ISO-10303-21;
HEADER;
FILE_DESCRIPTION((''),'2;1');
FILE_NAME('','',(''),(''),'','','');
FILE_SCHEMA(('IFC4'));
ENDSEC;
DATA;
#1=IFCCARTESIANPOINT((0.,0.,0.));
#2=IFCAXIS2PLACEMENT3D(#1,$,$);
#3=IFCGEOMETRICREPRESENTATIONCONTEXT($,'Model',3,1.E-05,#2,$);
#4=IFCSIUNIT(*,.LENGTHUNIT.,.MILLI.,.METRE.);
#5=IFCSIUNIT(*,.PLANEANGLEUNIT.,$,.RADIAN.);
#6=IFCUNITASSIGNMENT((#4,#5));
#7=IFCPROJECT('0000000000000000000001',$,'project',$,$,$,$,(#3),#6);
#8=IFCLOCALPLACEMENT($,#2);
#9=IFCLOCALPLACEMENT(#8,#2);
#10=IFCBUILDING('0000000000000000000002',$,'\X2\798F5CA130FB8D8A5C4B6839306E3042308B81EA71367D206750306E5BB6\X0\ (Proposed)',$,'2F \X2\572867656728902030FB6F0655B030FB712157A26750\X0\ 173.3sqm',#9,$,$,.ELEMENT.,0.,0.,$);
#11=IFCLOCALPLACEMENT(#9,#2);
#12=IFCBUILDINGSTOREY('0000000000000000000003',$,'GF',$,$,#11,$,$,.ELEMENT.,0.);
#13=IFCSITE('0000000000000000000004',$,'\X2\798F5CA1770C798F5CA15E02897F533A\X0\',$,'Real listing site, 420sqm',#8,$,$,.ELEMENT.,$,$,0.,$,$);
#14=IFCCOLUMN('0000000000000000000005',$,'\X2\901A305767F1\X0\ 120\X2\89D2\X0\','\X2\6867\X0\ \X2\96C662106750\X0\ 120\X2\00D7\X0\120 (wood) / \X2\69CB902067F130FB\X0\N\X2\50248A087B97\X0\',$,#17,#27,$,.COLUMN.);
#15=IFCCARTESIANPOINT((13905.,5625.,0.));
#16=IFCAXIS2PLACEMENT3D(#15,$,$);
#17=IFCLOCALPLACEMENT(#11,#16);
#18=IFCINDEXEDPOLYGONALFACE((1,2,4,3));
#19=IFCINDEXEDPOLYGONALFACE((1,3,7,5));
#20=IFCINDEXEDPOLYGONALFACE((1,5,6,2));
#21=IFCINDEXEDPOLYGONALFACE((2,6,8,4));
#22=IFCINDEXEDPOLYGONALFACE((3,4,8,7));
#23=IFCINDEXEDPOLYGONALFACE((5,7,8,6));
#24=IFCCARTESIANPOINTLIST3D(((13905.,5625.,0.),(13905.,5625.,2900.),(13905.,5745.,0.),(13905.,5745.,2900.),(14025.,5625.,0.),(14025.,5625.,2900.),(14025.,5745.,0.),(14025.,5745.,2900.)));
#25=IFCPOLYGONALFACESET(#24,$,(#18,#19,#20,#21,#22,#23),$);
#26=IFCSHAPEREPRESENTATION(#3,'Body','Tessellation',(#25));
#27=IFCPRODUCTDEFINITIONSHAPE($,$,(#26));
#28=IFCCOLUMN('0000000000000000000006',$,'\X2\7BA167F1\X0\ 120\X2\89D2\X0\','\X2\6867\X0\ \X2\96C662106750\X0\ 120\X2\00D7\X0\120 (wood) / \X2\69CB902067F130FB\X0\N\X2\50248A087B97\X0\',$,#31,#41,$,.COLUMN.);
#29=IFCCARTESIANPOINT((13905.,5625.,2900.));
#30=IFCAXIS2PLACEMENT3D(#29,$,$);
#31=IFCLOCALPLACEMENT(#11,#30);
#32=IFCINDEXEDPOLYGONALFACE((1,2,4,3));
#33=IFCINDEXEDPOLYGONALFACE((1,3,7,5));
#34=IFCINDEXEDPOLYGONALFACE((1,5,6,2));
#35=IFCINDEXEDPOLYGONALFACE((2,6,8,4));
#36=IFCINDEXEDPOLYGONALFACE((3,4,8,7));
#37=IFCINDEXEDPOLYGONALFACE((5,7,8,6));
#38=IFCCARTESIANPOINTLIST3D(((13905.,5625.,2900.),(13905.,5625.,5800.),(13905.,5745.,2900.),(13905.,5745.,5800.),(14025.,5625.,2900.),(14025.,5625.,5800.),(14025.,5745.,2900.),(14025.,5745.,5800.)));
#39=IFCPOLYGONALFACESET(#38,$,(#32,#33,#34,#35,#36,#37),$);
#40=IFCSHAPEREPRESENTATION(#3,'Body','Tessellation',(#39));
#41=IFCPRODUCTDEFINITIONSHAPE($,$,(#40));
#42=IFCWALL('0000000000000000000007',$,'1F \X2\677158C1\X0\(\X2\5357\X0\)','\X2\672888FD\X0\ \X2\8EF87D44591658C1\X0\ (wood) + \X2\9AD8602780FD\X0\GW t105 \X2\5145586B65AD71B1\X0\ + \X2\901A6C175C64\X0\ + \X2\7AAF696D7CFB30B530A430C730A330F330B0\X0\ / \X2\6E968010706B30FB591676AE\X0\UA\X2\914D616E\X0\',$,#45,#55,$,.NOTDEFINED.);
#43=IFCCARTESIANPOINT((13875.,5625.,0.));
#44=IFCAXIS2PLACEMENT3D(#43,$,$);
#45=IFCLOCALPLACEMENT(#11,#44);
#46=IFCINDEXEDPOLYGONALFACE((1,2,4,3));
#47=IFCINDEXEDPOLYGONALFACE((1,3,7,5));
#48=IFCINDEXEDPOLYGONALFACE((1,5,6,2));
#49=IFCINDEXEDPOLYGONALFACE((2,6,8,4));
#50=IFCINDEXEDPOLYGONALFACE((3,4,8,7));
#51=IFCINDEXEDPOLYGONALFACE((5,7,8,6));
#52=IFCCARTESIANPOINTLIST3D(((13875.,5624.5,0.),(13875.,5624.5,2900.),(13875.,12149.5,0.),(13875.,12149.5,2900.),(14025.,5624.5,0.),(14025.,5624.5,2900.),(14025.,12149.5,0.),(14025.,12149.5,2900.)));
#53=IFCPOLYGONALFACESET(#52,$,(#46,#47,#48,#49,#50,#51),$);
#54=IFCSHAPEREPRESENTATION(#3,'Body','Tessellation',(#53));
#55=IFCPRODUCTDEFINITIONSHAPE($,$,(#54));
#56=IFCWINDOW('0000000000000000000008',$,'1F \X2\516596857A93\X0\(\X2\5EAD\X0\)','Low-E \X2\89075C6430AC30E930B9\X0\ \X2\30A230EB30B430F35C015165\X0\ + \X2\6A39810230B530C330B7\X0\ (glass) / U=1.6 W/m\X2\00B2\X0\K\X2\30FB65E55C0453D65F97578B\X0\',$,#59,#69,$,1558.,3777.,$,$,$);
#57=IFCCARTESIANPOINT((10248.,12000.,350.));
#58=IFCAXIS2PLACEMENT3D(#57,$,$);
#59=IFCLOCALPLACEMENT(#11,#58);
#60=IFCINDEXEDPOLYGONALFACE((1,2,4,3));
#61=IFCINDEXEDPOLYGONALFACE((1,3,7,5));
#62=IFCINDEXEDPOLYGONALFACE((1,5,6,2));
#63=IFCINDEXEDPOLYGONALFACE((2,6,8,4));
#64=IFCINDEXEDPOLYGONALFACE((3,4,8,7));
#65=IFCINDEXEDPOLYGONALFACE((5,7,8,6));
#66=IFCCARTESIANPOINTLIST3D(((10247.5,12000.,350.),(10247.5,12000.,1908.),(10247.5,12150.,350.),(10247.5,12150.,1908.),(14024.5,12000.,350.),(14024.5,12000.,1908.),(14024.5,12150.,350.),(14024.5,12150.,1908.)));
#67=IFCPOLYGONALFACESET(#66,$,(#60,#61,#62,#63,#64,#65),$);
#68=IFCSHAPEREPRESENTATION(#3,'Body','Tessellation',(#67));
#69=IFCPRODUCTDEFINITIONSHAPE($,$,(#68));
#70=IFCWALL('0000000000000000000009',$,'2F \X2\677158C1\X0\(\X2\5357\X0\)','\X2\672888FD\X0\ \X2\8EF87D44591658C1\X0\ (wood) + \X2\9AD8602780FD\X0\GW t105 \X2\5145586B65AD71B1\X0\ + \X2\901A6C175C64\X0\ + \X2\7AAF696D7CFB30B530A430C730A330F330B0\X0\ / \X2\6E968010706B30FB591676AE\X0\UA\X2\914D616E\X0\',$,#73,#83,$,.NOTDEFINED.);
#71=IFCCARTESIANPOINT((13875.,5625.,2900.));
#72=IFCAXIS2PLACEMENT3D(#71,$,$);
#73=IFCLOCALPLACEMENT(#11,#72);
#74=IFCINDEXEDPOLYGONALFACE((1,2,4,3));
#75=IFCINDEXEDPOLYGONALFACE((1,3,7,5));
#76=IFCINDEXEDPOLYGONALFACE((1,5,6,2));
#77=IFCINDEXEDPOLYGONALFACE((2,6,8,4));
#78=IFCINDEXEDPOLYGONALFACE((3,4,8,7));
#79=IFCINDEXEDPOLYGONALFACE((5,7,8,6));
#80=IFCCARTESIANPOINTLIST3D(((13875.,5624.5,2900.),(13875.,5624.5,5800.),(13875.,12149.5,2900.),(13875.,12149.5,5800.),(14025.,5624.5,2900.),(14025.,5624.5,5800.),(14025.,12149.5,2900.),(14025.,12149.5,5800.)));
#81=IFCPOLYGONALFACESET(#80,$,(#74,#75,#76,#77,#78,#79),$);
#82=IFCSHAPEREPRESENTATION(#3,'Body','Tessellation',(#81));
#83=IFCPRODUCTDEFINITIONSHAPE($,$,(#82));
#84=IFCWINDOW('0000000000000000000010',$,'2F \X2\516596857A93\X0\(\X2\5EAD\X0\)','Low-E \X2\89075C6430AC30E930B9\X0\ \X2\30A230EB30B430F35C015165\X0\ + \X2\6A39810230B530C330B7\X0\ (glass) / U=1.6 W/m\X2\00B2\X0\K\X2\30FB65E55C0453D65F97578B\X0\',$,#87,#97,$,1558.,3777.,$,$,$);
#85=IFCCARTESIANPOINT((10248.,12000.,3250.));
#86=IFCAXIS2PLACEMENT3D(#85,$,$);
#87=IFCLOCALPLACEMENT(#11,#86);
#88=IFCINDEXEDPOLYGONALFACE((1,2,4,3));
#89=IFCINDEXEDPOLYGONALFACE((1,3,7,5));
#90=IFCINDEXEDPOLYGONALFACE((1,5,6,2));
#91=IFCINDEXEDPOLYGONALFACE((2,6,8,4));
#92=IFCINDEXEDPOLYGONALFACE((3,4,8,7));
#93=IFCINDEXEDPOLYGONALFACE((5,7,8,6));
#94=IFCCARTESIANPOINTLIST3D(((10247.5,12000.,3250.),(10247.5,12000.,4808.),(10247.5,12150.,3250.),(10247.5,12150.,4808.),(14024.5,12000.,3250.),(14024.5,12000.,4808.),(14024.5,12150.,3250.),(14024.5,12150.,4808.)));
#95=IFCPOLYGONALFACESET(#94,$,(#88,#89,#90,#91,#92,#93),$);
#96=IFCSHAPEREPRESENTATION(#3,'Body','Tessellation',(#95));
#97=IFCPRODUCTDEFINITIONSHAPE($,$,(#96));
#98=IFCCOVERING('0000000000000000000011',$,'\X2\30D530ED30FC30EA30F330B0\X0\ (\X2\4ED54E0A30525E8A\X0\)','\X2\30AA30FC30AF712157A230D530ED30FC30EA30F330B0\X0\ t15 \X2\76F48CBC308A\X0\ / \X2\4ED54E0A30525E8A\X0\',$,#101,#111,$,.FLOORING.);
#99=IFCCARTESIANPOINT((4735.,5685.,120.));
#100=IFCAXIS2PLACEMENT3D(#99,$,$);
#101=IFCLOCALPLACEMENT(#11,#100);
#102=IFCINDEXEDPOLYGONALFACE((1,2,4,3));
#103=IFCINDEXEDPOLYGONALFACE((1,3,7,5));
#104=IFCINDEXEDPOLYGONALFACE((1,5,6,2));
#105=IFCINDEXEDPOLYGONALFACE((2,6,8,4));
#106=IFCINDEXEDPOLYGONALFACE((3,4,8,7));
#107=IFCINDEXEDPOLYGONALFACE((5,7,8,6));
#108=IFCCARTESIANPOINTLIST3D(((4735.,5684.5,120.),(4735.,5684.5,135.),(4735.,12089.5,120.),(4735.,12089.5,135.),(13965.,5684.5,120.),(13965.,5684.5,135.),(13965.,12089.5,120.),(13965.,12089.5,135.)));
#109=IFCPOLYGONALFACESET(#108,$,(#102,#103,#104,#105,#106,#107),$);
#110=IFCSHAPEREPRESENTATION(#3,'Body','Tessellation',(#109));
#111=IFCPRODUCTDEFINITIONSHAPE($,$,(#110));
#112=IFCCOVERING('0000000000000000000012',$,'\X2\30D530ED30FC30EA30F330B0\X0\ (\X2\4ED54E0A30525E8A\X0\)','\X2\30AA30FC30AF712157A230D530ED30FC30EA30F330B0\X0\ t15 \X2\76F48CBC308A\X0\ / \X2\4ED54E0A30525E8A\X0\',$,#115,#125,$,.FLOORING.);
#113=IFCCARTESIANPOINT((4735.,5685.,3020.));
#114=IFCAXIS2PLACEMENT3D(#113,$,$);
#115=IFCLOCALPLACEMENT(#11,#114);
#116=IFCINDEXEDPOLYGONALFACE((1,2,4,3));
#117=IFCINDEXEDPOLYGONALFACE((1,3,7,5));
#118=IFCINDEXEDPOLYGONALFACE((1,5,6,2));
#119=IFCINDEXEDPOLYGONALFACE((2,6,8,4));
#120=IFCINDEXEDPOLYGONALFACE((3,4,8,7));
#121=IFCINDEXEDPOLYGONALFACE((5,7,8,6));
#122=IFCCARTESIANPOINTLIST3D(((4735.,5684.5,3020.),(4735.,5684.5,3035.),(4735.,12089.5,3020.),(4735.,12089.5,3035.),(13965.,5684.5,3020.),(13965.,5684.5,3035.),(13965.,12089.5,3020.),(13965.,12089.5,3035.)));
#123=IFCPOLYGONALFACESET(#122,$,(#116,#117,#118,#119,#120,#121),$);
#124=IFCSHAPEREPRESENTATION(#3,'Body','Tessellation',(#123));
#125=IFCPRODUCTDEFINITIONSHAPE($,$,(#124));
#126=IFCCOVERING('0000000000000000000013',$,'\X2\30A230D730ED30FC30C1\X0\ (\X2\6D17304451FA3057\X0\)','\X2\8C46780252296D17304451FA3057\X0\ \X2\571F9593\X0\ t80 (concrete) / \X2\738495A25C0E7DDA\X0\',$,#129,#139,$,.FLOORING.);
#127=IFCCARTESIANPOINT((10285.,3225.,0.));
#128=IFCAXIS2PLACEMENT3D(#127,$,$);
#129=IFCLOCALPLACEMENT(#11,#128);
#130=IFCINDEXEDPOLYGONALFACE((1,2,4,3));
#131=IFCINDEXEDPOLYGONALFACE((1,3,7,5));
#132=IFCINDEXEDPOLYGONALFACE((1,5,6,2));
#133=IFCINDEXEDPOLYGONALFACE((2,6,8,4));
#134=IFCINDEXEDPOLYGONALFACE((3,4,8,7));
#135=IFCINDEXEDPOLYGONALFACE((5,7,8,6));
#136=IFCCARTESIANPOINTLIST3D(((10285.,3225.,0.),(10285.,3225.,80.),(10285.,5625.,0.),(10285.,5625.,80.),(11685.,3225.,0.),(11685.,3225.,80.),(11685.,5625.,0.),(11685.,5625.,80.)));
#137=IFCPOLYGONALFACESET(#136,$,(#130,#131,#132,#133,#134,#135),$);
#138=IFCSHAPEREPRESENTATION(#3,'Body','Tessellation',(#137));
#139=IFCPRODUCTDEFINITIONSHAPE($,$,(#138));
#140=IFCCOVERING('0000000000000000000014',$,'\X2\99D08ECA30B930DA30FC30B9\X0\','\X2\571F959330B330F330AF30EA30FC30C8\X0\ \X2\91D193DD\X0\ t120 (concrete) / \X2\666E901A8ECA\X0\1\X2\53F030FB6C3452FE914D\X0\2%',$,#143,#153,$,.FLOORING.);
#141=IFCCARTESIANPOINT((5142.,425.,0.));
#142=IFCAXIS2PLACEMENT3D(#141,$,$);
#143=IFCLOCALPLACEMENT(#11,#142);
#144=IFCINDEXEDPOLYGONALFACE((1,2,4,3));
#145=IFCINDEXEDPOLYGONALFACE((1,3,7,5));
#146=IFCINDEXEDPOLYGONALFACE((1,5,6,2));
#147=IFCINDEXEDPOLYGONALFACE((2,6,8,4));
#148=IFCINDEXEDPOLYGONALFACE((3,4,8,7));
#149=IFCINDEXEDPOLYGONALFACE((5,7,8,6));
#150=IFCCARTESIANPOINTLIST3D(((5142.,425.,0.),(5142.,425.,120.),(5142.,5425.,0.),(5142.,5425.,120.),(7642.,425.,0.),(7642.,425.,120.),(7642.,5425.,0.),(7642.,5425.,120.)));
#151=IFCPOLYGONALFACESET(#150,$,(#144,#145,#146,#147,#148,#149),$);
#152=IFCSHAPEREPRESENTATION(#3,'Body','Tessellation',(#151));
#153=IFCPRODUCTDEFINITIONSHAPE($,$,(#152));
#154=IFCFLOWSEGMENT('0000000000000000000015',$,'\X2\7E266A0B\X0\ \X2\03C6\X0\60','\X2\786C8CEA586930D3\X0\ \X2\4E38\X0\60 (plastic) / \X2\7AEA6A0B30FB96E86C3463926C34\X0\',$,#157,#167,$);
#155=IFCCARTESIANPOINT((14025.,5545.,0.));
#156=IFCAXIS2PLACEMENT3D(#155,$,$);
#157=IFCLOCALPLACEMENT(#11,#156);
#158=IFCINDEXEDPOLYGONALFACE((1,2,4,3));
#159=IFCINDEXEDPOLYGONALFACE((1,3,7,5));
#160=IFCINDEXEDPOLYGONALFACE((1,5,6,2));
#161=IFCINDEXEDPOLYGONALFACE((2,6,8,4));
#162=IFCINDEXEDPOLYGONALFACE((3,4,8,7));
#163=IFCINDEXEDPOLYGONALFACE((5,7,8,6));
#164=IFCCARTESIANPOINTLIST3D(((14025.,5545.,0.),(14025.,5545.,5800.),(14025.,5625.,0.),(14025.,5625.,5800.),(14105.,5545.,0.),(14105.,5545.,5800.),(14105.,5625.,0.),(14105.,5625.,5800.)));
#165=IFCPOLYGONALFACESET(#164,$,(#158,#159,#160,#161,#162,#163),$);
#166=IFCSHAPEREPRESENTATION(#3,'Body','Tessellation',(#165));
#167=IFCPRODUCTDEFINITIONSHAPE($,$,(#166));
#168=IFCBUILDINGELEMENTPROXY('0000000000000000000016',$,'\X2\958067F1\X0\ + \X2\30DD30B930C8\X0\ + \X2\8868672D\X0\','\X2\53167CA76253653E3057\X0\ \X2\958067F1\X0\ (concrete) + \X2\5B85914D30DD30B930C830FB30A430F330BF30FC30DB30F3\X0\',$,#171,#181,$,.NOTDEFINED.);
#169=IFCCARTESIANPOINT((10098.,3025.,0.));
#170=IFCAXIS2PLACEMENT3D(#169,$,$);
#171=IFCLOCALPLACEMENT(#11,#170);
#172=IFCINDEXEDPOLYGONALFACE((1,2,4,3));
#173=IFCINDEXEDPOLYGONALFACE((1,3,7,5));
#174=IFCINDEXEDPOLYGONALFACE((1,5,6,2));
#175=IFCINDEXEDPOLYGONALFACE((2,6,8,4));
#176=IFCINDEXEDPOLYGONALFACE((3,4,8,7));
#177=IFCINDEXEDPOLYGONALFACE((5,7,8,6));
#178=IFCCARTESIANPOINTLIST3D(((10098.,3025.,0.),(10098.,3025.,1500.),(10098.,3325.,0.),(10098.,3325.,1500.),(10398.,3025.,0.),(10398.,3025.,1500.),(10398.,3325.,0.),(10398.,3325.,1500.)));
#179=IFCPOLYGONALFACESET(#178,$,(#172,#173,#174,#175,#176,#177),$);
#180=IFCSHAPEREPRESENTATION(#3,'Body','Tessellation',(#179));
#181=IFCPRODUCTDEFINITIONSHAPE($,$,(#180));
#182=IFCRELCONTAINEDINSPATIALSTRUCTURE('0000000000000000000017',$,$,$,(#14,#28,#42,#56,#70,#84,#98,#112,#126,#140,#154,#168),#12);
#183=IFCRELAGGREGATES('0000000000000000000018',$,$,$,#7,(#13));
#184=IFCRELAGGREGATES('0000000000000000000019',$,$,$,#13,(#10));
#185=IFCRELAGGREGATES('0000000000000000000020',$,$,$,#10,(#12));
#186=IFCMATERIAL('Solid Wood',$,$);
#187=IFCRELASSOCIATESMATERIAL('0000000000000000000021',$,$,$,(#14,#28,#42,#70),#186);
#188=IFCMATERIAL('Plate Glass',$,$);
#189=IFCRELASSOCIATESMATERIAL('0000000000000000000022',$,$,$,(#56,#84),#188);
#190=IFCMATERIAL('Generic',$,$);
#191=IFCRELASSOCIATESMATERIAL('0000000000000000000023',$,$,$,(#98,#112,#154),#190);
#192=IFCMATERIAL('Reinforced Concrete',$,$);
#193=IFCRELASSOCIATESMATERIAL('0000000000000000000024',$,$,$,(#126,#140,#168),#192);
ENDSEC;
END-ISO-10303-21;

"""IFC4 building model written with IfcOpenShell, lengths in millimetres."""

from ifc_helpers import new_model, si_unit, frame, frame_2d, origin, place, context, project, spatial, rectangle, extrude, material, element, fill, save


model = new_model("IFC4")

# Units and contexts
model_context = context("Model", 3, precision=1e-05, world=origin())
ifc_project = project(units=[si_unit("LENGTHUNIT", "METRE", prefix="MILLI"), si_unit("PLANEANGLEUNIT", "RADIAN")], contexts=[model_context])

# Site, building, storey
site_placement = place(None, origin())
site = spatial("IfcSite", under=ifc_project, at=site_placement, Name="福岡県福岡市西区", ObjectType="Real listing site, 420sqm", CompositionType="ELEMENT", RefElevation=0.0)
building_placement = place(site_placement, origin())
building = spatial("IfcBuilding", under=site, at=building_placement, Name="福岡・越屋根のある自然素材の家 (Proposed)", ObjectType="2F 在来木造・漆喰・無垢材 173.3sqm", CompositionType="ELEMENT", ElevationOfRefHeight=0.0, ElevationOfTerrain=0.0)
storey_placement = place(building_placement, origin())
storey = spatial("IfcBuildingStorey", under=building, at=storey_placement, Name="GF", CompositionType="ELEMENT", Elevation=0.0)

# Columns
ifc_material_1 = material(Name="Solid Wood")
column_1_placement = place(storey_placement, frame((13905.0, 5625.0, 0.0)))
element("IfcColumn", 1, at=column_1_placement, inside=storey, material=ifc_material_1, Name="通し柱 120角", Description="桧 集成材 120×120 (wood) / 構造柱・N値計算", PredefinedType="COLUMN", context=model_context, shape_type="SweptSolid", body=[
    extrude(rectangle(XDim=120.0, YDim=120.0, at=frame_2d((60.0, 60.0))), frame((13905.0, 5625.0, 0.0)), (0.0, 0.0, 1.0), 2900.0),
])
column_2_placement = place(storey_placement, frame((13905.0, 5625.0, 2900.0)))
element("IfcColumn", 2, at=column_2_placement, inside=storey, material=ifc_material_1, Name="管柱 120角", Description="桧 集成材 120×120 (wood) / 構造柱・N値計算", PredefinedType="COLUMN", context=model_context, shape_type="SweptSolid", body=[
    extrude(rectangle(XDim=120.0, YDim=120.0, at=frame_2d((60.0, 60.0))), frame((13905.0, 5625.0, 2900.0)), (0.0, 0.0, 1.0), 2900.0),
])

# Wall, opening, window
wall_1_placement = place(storey_placement, frame((13875.0, 5625.0, 0.0)))
wall_1 = element("IfcWall", 3, at=wall_1_placement, inside=storey, material=ifc_material_1, Name="1F 東壁(南)", Description="木製 軸組外壁 (wood) + 高性能GW t105 充填断熱 + 通気層 + 窯業系サイディング / 準耐火・外皮UA配慮", PredefinedType="NOTDEFINED", context=model_context, shape_type="SweptSolid", body=[
    extrude(rectangle(XDim=150.0, YDim=6525.0, at=frame_2d((75.0, 3262.0))), frame((13875.0, 5625.0, 0.0)), (0.0, 0.0, 1.0), 2900.0),
])
opening_1_placement = place(storey_placement, frame((10248.0, 12000.0, 350.0)))
opening_1 = element("IfcOpeningElement", 4, at=opening_1_placement, cuts=wall_1, PredefinedType="NOTDEFINED", context=model_context, shape_type="SweptSolid", body=[
    extrude(rectangle(XDim=3777.0, YDim=150.0, at=frame_2d((1888.0, 75.0))), frame((10248.0, 12000.0, 350.0)), (0.0, 0.0, 1.0), 1558.0),
])
ifc_material_2 = material(Name="Plate Glass")
window_1_placement = place(storey_placement, frame((10248.0, 12000.0, 350.0)))
window_1 = element("IfcWindow", 5, at=window_1_placement, inside=storey, material=ifc_material_2, Name="1F 入隅窓(庭)", Description="Low-E 複層ガラス アルゴン封入 + 樹脂サッシ (glass) / U=1.6 W/m²K・日射取得型", OverallHeight=1558.0, OverallWidth=3777.0, context=model_context, shape_type="SweptSolid", body=[
    extrude(rectangle(XDim=3777.0, YDim=150.0, at=frame_2d((1888.0, 75.0))), frame((10248.0, 12000.0, 350.0)), (0.0, 0.0, 1.0), 1558.0),
])
fill(opening_1, window_1)

# Wall, opening, window
wall_2_placement = place(storey_placement, frame((13875.0, 5625.0, 2900.0)))
wall_2 = element("IfcWall", 6, at=wall_2_placement, inside=storey, material=ifc_material_1, Name="2F 東壁(南)", Description="木製 軸組外壁 (wood) + 高性能GW t105 充填断熱 + 通気層 + 窯業系サイディング / 準耐火・外皮UA配慮", PredefinedType="NOTDEFINED", context=model_context, shape_type="SweptSolid", body=[
    extrude(rectangle(XDim=150.0, YDim=6525.0, at=frame_2d((75.0, 3262.0))), frame((13875.0, 5625.0, 2900.0)), (0.0, 0.0, 1.0), 2900.0),
])
opening_2_placement = place(storey_placement, frame((10248.0, 12000.0, 3250.0)))
opening_2 = element("IfcOpeningElement", 7, at=opening_2_placement, cuts=wall_2, PredefinedType="NOTDEFINED", context=model_context, shape_type="SweptSolid", body=[
    extrude(rectangle(XDim=3777.0, YDim=150.0, at=frame_2d((1888.0, 75.0))), frame((10248.0, 12000.0, 3250.0)), (0.0, 0.0, 1.0), 1558.0),
])
window_2_placement = place(storey_placement, frame((10248.0, 12000.0, 3250.0)))
window_2 = element("IfcWindow", 8, at=window_2_placement, inside=storey, material=ifc_material_2, Name="2F 入隅窓(庭)", Description="Low-E 複層ガラス アルゴン封入 + 樹脂サッシ (glass) / U=1.6 W/m²K・日射取得型", OverallHeight=1558.0, OverallWidth=3777.0, context=model_context, shape_type="SweptSolid", body=[
    extrude(rectangle(XDim=3777.0, YDim=150.0, at=frame_2d((1888.0, 75.0))), frame((10248.0, 12000.0, 3250.0)), (0.0, 0.0, 1.0), 1558.0),
])
fill(opening_2, window_2)

# Coverings
ifc_material_3 = material(Name="Generic")
covering_1_placement = place(storey_placement, frame((4735.0, 5685.0, 120.0)))
element("IfcCovering", 9, at=covering_1_placement, inside=storey, material=ifc_material_3, Name="フローリング (仕上げ床)", Description="オーク無垢フローリング t15 直貼り / 仕上げ床", PredefinedType="FLOORING", context=model_context, shape_type="SweptSolid", body=[
    extrude(rectangle(XDim=9230.0, YDim=6405.0, at=frame_2d((4615.0, 3202.0))), frame((4735.0, 5685.0, 120.0)), (0.0, 0.0, 1.0), 15.0),
])
covering_2_placement = place(storey_placement, frame((4735.0, 5685.0, 3020.0)))
element("IfcCovering", 10, at=covering_2_placement, inside=storey, material=ifc_material_3, Name="フローリング (仕上げ床)", Description="オーク無垢フローリング t15 直貼り / 仕上げ床", PredefinedType="FLOORING", context=model_context, shape_type="SweptSolid", body=[
    extrude(rectangle(XDim=9230.0, YDim=6405.0, at=frame_2d((4615.0, 3202.0))), frame((4735.0, 5685.0, 3020.0)), (0.0, 0.0, 1.0), 15.0),
])
ifc_material_4 = material(Name="Reinforced Concrete")
covering_3_placement = place(storey_placement, frame((10285.0, 3225.0, 0.0)))
element("IfcCovering", 11, at=covering_3_placement, inside=storey, material=ifc_material_4, Name="アプローチ (洗い出し)", Description="豆砂利洗い出し 土間 t80 (concrete) / 玄関導線", PredefinedType="FLOORING", context=model_context, shape_type="SweptSolid", body=[
    extrude(rectangle(XDim=1400.0, YDim=2400.0, at=frame_2d((700.0, 1200.0))), frame((10285.0, 3225.0, 0.0)), (0.0, 0.0, 1.0), 80.0),
])
covering_4_placement = place(storey_placement, frame((5142.0, 425.0, 0.0)))
element("IfcCovering", 12, at=covering_4_placement, inside=storey, material=ifc_material_4, Name="駐車スペース", Description="土間コンクリート 金鏝 t120 (concrete) / 普通車1台・水勾配2%", PredefinedType="FLOORING", context=model_context, shape_type="SweptSolid", body=[
    extrude(rectangle(XDim=2500.0, YDim=5000.0, at=frame_2d((1250.0, 2500.0))), frame((5142.0, 425.0, 0.0)), (0.0, 0.0, 1.0), 120.0),
])

# Flow segment
flow_segment_placement = place(storey_placement, frame((14025.0, 5545.0, 0.0)))
element("IfcFlowSegment", 13, at=flow_segment_placement, inside=storey, material=ifc_material_3, Name="縦樋 φ60", Description="硬質塩ビ 丸60 (plastic) / 竪樋・雨水排水", context=model_context, shape_type="SweptSolid", body=[
    extrude(rectangle(XDim=80.0, YDim=80.0, at=frame_2d((40.0, 40.0))), frame((14025.0, 5545.0, 0.0)), (0.0, 0.0, 1.0), 5800.0),
])

# Building element proxy
proxy_placement = place(storey_placement, frame((10098.0, 3025.0, 0.0)))
element("IfcBuildingElementProxy", 14, at=proxy_placement, inside=storey, material=ifc_material_4, Name="門柱 + ポスト + 表札", Description="化粧打放し 門柱 (concrete) + 宅配ポスト・インターホン", PredefinedType="NOTDEFINED", context=model_context, shape_type="SweptSolid", body=[
    extrude(rectangle(XDim=300.0, YDim=300.0, at=frame_2d((150.0, 150.0))), frame((10098.0, 3025.0, 0.0)), (0.0, 0.0, 1.0), 1500.0),
])

save(model, "model.ifc")
